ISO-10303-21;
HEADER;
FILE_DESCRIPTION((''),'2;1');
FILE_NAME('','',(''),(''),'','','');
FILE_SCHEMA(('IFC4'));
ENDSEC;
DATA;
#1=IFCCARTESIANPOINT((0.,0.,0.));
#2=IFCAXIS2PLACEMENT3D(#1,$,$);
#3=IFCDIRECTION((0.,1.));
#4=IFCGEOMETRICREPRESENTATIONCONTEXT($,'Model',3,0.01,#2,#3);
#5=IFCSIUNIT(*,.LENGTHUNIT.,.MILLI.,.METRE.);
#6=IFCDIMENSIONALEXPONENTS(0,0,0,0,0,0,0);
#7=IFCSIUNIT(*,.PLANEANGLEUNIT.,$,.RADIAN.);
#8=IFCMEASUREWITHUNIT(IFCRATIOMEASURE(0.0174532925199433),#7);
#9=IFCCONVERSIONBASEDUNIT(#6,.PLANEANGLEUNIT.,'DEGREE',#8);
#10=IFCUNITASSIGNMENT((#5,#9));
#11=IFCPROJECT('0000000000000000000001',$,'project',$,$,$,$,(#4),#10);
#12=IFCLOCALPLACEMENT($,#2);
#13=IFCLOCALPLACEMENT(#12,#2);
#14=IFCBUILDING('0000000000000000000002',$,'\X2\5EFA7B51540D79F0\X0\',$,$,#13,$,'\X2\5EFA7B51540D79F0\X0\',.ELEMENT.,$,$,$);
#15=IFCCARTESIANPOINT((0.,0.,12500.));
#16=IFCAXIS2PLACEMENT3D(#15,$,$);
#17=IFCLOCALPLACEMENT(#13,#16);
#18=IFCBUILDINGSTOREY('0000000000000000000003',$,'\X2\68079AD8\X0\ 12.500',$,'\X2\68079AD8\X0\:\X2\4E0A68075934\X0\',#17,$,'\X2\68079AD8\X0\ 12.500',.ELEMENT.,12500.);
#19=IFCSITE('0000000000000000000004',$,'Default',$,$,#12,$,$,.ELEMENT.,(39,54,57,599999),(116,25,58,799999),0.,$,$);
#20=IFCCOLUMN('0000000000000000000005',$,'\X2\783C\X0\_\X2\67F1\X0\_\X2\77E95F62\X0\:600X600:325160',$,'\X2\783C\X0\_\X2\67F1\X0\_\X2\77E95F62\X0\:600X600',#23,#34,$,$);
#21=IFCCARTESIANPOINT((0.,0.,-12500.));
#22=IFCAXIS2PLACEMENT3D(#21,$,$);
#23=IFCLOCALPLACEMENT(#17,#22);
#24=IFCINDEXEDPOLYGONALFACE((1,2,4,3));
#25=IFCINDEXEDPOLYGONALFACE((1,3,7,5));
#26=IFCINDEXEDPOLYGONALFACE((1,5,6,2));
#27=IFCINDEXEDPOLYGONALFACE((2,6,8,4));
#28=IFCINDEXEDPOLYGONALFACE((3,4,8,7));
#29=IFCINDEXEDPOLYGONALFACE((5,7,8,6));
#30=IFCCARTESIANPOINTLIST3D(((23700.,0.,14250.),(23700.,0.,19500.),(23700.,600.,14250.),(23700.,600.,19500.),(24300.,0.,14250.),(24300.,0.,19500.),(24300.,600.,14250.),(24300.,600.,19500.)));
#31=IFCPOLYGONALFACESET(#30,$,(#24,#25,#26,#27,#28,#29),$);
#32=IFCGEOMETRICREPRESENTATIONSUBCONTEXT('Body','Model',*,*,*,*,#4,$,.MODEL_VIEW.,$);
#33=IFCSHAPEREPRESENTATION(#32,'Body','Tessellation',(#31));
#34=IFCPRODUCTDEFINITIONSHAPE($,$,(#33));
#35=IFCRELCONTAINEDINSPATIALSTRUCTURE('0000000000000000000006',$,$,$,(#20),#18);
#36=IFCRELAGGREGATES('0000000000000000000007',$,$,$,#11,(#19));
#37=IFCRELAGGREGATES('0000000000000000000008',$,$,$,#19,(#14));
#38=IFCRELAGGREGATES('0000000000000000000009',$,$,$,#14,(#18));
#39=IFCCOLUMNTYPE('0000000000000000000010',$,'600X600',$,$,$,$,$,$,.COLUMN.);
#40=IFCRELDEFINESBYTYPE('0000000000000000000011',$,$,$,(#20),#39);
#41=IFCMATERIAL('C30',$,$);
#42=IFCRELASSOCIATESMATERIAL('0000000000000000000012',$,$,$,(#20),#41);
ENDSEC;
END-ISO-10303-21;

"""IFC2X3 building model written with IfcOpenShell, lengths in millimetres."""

from ifc_helpers import new_model, entity, si_unit, converted_unit, direction, frame, origin, origin_2d_with_axis, place, context, subcontext, project, spatial, rectangle, extrude, source, transform, mapped, material, type_object, type_shapes, element, save


model = new_model("IFC2X3")

# Units and contexts
model_context = context("Model", 3, precision=0.01, world=origin(), true_north=direction((0.0, 1.0)))
body_context = subcontext(model_context, "Body", "Model", "MODEL_VIEW")
ifc_project = project(units=[si_unit("LENGTHUNIT", "METRE", prefix="MILLI"), converted_unit("PLANEANGLEUNIT", "DEGREE", entity("IfcRatioMeasure", 0.0174532925199433), si_unit("PLANEANGLEUNIT", "RADIAN"), dimensions=[0, 0, 0, 0, 0, 0, 0])], contexts=[model_context])

# Site, building, storey
site_placement = place(None, origin())
site = spatial("IfcSite", under=ifc_project, at=site_placement, Name="Default", CompositionType="ELEMENT", RefLatitude=(39, 54, 57, 599999), RefLongitude=(116, 25, 58, 799999), RefElevation=0.0)
building_placement = place(site_placement, origin())
building = spatial("IfcBuilding", under=site, at=building_placement, Name="建筑名称", LongName="建筑名称", CompositionType="ELEMENT")
storey_placement = place(building_placement, frame((0.0, 0.0, 12500.0)))
storey = spatial("IfcBuildingStorey", under=building, at=storey_placement, Name="标高 12.500", ObjectType="标高:上标头", LongName="标高 12.500", CompositionType="ELEMENT", Elevation=12500.0)

# Column
ifc_material = material(Name="C30")
column_type = type_object("IfcColumnType", Name="600X600", PredefinedType="COLUMN")
shared_shape_1 = source(origin(), body_context, "Body", "SweptSolid", [
    extrude(rectangle(XDim=600.0, YDim=600.0, at=origin_2d_with_axis()), frame((24000.0, 300.0, 14250.0), z_axis=(0.0, 0.0, 1.0), x_axis=(0.0, -1.0, 0.0)), (0.0, 0.0, 1.0), 5250.0),
])
type_shapes(column_type, [shared_shape_1])
column_placement = place(storey_placement, frame((0.0, 0.0, -12500.0)))
element("IfcColumn", 1, at=column_placement, inside=storey, type_object=column_type, material=ifc_material, Name="砼_柱_矩形:600X600:325160", ObjectType="砼_柱_矩形:600X600", context=body_context, shape_type="MappedRepresentation", body=[
    mapped(shared_shape_1, transform((0.0, 0.0, 0.0), scale=1.0)),
])

save(model, "model.ifc")
